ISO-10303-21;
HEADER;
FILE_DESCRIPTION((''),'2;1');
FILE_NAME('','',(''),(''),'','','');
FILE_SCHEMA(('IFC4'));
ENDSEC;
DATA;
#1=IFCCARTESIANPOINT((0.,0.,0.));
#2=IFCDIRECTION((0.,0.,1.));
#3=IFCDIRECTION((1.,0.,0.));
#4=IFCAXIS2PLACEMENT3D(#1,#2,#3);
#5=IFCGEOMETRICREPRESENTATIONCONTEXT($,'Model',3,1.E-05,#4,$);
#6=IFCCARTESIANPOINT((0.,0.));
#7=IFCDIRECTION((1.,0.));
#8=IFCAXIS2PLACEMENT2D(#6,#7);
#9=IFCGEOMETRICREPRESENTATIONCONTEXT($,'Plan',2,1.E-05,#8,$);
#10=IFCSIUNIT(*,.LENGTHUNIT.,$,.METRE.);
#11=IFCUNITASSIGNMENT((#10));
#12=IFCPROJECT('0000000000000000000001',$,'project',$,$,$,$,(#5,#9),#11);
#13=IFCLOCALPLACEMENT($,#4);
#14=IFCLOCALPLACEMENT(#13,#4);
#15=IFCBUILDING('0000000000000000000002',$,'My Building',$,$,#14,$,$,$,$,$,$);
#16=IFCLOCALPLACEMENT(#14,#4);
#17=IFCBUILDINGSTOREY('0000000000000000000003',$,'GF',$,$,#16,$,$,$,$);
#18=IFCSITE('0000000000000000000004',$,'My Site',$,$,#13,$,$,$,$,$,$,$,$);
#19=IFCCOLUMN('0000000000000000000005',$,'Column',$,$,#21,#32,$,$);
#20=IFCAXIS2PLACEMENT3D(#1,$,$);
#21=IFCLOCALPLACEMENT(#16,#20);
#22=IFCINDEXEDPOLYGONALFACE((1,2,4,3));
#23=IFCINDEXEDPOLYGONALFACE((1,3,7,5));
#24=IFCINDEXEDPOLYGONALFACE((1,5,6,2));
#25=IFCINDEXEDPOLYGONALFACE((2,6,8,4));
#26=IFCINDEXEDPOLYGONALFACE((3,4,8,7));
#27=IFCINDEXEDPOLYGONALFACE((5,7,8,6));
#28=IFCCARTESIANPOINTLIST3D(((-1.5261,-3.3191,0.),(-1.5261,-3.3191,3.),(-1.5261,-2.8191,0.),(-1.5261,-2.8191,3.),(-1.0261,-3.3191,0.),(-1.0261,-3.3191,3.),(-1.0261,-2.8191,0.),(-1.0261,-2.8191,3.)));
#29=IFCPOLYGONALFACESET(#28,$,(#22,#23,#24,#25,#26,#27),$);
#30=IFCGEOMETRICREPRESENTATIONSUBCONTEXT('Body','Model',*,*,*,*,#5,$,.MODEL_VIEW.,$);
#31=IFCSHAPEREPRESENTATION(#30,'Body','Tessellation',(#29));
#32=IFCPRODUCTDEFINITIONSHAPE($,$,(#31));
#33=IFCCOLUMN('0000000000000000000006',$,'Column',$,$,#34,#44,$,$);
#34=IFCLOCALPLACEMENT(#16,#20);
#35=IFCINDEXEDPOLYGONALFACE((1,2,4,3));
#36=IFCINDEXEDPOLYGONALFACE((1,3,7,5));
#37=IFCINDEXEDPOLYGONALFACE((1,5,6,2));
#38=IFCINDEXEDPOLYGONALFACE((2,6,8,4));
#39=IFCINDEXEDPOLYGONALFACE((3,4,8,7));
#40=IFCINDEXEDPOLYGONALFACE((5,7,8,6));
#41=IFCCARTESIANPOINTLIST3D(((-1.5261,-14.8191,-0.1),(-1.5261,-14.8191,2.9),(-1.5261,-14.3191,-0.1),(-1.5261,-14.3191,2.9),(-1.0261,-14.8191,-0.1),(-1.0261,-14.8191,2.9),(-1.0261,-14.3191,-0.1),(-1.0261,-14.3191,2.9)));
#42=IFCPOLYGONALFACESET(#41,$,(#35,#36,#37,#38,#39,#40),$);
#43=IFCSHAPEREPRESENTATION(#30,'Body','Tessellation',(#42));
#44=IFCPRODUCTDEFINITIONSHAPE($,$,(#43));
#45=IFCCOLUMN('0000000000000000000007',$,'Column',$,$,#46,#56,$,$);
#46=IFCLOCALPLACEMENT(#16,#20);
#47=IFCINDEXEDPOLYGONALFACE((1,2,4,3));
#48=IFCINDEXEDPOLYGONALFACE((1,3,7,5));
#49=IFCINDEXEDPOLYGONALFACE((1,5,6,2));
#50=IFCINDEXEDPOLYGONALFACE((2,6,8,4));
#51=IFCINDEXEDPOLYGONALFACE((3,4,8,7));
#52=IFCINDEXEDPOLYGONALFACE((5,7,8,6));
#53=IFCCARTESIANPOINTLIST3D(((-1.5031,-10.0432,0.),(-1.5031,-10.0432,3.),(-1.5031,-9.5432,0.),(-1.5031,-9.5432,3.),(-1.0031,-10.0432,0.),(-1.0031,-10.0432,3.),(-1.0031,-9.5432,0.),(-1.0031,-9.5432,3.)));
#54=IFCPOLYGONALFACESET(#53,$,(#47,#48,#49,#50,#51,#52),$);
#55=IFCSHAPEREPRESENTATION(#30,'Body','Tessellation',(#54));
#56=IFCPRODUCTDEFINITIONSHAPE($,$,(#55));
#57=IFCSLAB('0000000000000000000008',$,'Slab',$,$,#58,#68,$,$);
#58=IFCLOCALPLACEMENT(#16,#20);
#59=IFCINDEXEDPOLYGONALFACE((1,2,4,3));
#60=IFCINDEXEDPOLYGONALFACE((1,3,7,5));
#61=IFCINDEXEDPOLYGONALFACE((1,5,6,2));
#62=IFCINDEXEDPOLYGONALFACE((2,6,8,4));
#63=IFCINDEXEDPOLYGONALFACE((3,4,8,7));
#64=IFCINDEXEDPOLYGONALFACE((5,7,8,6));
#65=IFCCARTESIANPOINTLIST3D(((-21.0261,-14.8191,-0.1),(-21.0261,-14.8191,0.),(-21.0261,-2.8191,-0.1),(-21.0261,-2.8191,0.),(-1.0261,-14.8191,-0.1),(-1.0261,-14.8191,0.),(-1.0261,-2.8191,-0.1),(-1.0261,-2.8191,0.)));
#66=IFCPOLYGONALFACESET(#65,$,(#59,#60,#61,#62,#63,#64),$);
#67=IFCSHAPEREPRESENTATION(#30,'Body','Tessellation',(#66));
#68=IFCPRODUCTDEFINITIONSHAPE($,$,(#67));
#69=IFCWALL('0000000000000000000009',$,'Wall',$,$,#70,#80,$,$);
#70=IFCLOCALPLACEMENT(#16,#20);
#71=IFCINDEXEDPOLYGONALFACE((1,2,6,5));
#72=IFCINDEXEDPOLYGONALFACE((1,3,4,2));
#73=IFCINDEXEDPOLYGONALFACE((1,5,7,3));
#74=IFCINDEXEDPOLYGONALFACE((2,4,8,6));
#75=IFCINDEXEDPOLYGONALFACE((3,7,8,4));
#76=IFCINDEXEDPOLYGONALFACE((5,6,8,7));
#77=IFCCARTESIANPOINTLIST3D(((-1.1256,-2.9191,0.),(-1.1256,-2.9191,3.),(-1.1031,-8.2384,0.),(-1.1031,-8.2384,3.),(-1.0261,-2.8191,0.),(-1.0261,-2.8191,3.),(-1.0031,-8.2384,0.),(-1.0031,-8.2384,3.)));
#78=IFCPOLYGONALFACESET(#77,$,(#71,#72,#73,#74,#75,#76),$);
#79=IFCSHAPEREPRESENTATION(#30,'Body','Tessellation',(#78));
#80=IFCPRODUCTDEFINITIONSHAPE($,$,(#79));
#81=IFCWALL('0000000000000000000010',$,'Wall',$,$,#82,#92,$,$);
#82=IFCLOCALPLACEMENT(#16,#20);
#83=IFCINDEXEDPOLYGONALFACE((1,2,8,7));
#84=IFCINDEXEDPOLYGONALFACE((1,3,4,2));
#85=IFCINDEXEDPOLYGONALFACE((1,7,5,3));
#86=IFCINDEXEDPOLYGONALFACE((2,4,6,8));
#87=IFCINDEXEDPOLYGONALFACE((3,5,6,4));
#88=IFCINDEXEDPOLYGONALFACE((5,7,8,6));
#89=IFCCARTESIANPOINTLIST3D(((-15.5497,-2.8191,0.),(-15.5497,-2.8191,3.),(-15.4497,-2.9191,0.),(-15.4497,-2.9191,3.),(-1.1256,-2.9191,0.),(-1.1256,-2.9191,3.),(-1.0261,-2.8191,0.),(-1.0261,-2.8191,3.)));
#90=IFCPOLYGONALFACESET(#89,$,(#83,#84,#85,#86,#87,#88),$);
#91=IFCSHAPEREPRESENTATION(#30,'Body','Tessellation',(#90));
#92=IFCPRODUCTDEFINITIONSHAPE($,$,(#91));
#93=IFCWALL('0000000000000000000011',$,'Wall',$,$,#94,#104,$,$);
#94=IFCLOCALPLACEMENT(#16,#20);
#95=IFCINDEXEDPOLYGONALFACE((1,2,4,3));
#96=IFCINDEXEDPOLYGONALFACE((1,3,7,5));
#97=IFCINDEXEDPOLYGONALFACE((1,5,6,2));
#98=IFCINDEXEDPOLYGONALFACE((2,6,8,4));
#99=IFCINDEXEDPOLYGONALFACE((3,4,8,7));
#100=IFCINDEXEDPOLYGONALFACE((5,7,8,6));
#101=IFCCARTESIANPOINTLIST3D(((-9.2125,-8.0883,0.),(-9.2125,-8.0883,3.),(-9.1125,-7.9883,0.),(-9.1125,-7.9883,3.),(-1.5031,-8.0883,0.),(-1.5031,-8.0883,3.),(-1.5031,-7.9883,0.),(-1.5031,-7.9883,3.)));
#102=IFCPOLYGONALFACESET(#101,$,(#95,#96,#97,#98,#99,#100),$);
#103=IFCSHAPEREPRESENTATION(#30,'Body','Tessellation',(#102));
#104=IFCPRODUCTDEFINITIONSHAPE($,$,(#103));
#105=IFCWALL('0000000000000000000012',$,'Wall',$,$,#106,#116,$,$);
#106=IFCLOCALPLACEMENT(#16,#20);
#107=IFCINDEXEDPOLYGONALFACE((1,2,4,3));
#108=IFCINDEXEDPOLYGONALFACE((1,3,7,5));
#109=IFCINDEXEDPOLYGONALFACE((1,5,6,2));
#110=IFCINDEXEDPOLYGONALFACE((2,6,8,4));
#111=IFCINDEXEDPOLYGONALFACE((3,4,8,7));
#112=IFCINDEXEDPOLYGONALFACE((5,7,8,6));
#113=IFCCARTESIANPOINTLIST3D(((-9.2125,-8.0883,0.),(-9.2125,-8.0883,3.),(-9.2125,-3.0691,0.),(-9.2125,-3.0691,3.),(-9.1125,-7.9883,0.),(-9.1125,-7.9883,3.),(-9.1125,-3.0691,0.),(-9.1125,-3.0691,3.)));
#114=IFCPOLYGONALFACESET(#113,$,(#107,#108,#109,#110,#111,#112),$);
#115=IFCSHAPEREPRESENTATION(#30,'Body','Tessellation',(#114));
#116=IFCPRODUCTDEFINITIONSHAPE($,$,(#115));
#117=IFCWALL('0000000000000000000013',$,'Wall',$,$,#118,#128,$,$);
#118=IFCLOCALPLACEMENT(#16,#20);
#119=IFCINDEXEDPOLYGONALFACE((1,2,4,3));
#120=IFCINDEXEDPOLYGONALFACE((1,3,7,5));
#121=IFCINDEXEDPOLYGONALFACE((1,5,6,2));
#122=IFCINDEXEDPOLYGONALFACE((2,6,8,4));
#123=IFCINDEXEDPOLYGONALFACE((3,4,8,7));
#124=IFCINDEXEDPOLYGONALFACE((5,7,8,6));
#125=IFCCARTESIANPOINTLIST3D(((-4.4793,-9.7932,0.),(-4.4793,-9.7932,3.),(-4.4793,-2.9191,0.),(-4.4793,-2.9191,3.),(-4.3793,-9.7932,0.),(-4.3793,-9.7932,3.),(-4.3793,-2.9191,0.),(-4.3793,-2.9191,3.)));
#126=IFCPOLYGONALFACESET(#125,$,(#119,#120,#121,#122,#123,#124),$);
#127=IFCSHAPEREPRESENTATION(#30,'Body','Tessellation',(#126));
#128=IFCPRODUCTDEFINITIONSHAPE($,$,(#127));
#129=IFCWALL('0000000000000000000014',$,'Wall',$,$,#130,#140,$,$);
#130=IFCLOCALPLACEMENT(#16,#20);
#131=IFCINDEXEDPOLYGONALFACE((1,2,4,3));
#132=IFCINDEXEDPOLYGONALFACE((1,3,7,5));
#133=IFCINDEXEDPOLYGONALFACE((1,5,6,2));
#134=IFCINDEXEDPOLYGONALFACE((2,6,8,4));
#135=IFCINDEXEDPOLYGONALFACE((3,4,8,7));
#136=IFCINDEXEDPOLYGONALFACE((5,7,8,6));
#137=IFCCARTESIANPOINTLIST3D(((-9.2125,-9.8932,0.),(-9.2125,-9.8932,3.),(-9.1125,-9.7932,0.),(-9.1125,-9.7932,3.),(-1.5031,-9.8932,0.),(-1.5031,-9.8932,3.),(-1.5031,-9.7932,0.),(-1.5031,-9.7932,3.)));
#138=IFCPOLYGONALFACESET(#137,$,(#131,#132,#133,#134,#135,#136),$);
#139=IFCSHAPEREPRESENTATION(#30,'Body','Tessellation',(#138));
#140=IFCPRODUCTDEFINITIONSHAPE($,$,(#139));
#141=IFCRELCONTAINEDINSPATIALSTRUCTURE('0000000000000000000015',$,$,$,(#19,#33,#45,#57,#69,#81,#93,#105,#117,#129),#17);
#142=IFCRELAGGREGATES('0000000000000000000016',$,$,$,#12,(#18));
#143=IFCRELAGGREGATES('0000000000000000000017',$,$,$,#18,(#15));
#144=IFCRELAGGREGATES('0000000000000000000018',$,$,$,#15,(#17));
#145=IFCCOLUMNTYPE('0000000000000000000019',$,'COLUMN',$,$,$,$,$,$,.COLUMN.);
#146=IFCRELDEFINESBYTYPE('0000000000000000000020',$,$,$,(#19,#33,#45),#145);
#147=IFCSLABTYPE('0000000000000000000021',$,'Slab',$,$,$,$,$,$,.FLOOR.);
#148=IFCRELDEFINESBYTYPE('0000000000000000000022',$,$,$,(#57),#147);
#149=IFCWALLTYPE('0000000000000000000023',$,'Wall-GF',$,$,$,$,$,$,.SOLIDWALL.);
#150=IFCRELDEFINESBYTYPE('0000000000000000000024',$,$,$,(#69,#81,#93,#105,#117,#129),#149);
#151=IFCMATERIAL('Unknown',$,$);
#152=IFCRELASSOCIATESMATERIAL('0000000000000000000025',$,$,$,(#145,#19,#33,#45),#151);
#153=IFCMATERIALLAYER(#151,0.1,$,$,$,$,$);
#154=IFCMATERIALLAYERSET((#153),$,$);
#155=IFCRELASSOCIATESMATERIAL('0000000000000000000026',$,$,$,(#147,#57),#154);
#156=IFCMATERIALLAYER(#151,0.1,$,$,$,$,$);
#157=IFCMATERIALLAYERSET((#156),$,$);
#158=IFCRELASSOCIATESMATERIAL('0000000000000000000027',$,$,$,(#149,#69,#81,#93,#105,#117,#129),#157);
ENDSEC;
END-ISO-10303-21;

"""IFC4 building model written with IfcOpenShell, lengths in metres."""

from ifc_helpers import new_model, si_unit, frame, origin_with_axes, origin_2d_with_axis, place, context, subcontext, project, spatial, line, indexed_curve, rectangle, outline, extrude, material, layer, layer_set, layer_usage, material_profile, profile_set, profile_usage, type_object, element, save


model = new_model("IFC4")

# Units and contexts
model_context = context("Model", 3, precision=1e-05, world=origin_with_axes())
plan_context = context("Plan", 2, precision=1e-05, world=origin_2d_with_axis())
body_context_1 = subcontext(model_context, "Body", "Model", "MODEL_VIEW")
ifc_project = project(units=[si_unit("LENGTHUNIT", "METRE")], contexts=[model_context, plan_context])

# Site, building, storey
site_placement = place(None, origin_with_axes())
site = spatial("IfcSite", under=ifc_project, at=site_placement, Name="My Site")
building_placement = place(site_placement, origin_with_axes())
building = spatial("IfcBuilding", under=site, at=building_placement, Name="My Building")
storey_placement = place(building_placement, origin_with_axes())
storey = spatial("IfcBuildingStorey", under=building, at=storey_placement, Name="GF")

# Columns
ifc_material = material(Name="Unknown")
ifc_material_profile_1 = material_profile(ifc_material, rectangle(XDim=0.5, YDim=0.5))
ifc_profile_set_1 = profile_set([ifc_material_profile_1])
ifc_profile_usage_1 = profile_usage(ifc_profile_set_1, cardinal=5)
column_type = type_object("IfcColumnType", Name="COLUMN", PredefinedType="COLUMN", material=ifc_profile_set_1)
column_1_placement = place(storey_placement, frame((-1.2761, -3.0691, 0.0), z_axis=(0.0, 0.0, 1.0), x_axis=(1.0, 0.0, 0.0)))
element("IfcColumn", 1, at=column_1_placement, inside=storey, type_object=column_type, material=ifc_profile_usage_1, Name="Column", context=body_context_1, shape_type="SweptSolid", body=[
    extrude(rectangle(XDim=0.5, YDim=0.5), origin_with_axes(), (0.0, 0.0, 1.0), 3.0),
])
ifc_profile_usage_2 = profile_usage(ifc_profile_set_1, cardinal=5)
column_2_placement = place(storey_placement, frame((-1.2761, -14.5691, -0.1), z_axis=(0.0, 0.0, 1.0), x_axis=(1.0, 0.0, 0.0)))
element("IfcColumn", 2, at=column_2_placement, inside=storey, type_object=column_type, material=ifc_profile_usage_2, Name="Column", context=body_context_1, shape_type="SweptSolid", body=[
    extrude(rectangle(XDim=0.5, YDim=0.5), origin_with_axes(), (0.0, 0.0, 1.0), 3.0),
])
ifc_profile_usage_3 = profile_usage(ifc_profile_set_1, cardinal=5)
column_3_placement = place(storey_placement, frame((-1.2531, -9.7932, 0.0), z_axis=(0.0, 0.0, 1.0), x_axis=(1.0, 0.0, 0.0)))
element("IfcColumn", 3, at=column_3_placement, inside=storey, type_object=column_type, material=ifc_profile_usage_3, Name="Column", context=body_context_1, shape_type="SweptSolid", body=[
    extrude(rectangle(XDim=0.5, YDim=0.5), origin_with_axes(), (0.0, 0.0, 1.0), 3.0),
])

# Slab
ifc_layer_1 = layer(ifc_material, 0.1)
ifc_layer_set_1 = layer_set([ifc_layer_1])
ifc_layer_usage_1 = layer_usage(ifc_layer_set_1, "AXIS3", "POSITIVE", -0.1)
slab_type = type_object("IfcSlabType", Name="Slab", PredefinedType="FLOOR", material=ifc_layer_set_1)
slab_placement = place(storey_placement, frame((-1.0261, -2.8191, 0.0), z_axis=(0.0, 0.0, 1.0), x_axis=(1.0, 0.0, 0.0)))
element("IfcSlab", 4, at=slab_placement, inside=storey, type_object=slab_type, material=ifc_layer_usage_1, Name="Slab", context=body_context_1, shape_type="SweptSolid", body=[
    extrude(outline(indexed_curve([(0.0, 0.0), (0.0, -12.0), (-20.0, -12.0), (-20.0, 0.0), (0.0, 0.0)])), frame((0.0, 0.0, -0.1), z_axis=(0.0, 0.0, 1.0), x_axis=(1.0, 0.0, 0.0)), (0.0, 0.0, 1.0), 0.1),
])

# Shared definitions
ifc_layer_2 = layer(ifc_material, 0.1)
ifc_layer_set_2 = layer_set([ifc_layer_2])
wall_type = type_object("IfcWallType", Name="Wall-GF", PredefinedType="SOLIDWALL", material=ifc_layer_set_2)

# Walls
ifc_layer_usage_2 = layer_usage(ifc_layer_set_2, "AXIS2", "POSITIVE", 0.0)
wall_1_placement = place(storey_placement, frame((-1.0031, -8.2384, 0.0), z_axis=(0.0, 0.0, 1.0), x_axis=(-0.004239, 0.999991, 0.0)))
element("IfcWall", 5, at=wall_1_placement, inside=storey, type_object=wall_type, material=ifc_layer_usage_2, Name="Wall", context=body_context_1, shape_type="SweptSolid", body=[
    extrude(outline(indexed_curve([(0.0, 0.0), (0.0004, 0.1), (5.3198, 0.1), (5.4193, 0.0)], segments=[line(1, 2, 3, 4, 1)])), origin_with_axes(), (0.0, 0.0, 1.0), 3.0),
])
ifc_layer_usage_3 = layer_usage(ifc_layer_set_2, "AXIS2", "POSITIVE", 0.0)
wall_2_placement = place(storey_placement, frame((-1.0261, -2.8191, 0.0), z_axis=(0.0, 0.0, 1.0), x_axis=(-1.0, 0.0, 0.0)))
element("IfcWall", 6, at=wall_2_placement, inside=storey, type_object=wall_type, material=ifc_layer_usage_3, Name="Wall", context=body_context_1, shape_type="SweptSolid", body=[
    extrude(outline(indexed_curve([(0.0, 0.0), (0.0996, 0.1), (14.4236, 0.1), (14.5236, 0.0)], segments=[line(1, 2, 3, 4, 1)])), origin_with_axes(), (0.0, 0.0, 1.0), 3.0),
])
ifc_layer_usage_4 = layer_usage(ifc_layer_set_2, "AXIS2", "POSITIVE", 0.0)
wall_3_placement = place(storey_placement, frame((-1.5031, -7.9883, 0.0), z_axis=(0.0, 0.0, 1.0), x_axis=(-1.0, 0.0, 0.0)))
element("IfcWall", 7, at=wall_3_placement, inside=storey, type_object=wall_type, material=ifc_layer_usage_4, Name="Wall", context=body_context_1, shape_type="SweptSolid", body=[
    extrude(outline(indexed_curve([(0.0, 0.0), (0.0, 0.1), (7.7094, 0.1), (7.6094, 0.0)], segments=[line(1, 2, 3, 4, 1)])), origin_with_axes(), (0.0, 0.0, 1.0), 3.0),
])
ifc_layer_usage_5 = layer_usage(ifc_layer_set_2, "AXIS2", "POSITIVE", 0.0)
wall_4_placement = place(storey_placement, frame((-9.1125, -7.9883, 0.0), z_axis=(0.0, 0.0, 1.0), x_axis=(0.0, 1.0, 0.0)))
element("IfcWall", 8, at=wall_4_placement, inside=storey, type_object=wall_type, material=ifc_layer_usage_5, Name="Wall", context=body_context_1, shape_type="SweptSolid", body=[
    extrude(outline(indexed_curve([(0.0, 0.0), (-0.1, 0.1), (4.9192, 0.1), (4.9192, 0.0)], segments=[line(1, 2, 3, 4, 1)])), origin_with_axes(), (0.0, 0.0, 1.0), 3.0),
])
ifc_layer_usage_6 = layer_usage(ifc_layer_set_2, "AXIS2", "POSITIVE", 0.0)
wall_5_placement = place(storey_placement, frame((-4.3793, -9.7932, 0.0), z_axis=(0.0, 0.0, 1.0), x_axis=(0.0, 1.0, 0.0)))
element("IfcWall", 9, at=wall_5_placement, inside=storey, type_object=wall_type, material=ifc_layer_usage_6, Name="Wall", context=body_context_1, shape_type="SweptSolid", body=[
    extrude(outline(indexed_curve([(0.0, 0.0), (0.0, 0.1), (6.8741, 0.1), (6.8741, 0.0)], segments=[line(1, 2, 3, 4, 1)])), origin_with_axes(), (0.0, 0.0, 1.0), 3.0),
])
ifc_layer_usage_7 = layer_usage(ifc_layer_set_2, "AXIS2", "POSITIVE", 0.0)
wall_6_placement = place(storey_placement, frame((-1.5031, -9.7932, 0.0), z_axis=(0.0, 0.0, 1.0), x_axis=(-1.0, 0.0, 0.0)))
element("IfcWall", 10, at=wall_6_placement, inside=storey, type_object=wall_type, material=ifc_layer_usage_7, Name="Wall", context=body_context_1, shape_type="SweptSolid", body=[
    extrude(outline(indexed_curve([(0.0, 0.0), (0.0, 0.1), (7.7094, 0.1), (7.6094, 0.0)], segments=[line(1, 2, 3, 4, 1)])), origin_with_axes(), (0.0, 0.0, 1.0), 3.0),
])

save(model, "model.ifc")
